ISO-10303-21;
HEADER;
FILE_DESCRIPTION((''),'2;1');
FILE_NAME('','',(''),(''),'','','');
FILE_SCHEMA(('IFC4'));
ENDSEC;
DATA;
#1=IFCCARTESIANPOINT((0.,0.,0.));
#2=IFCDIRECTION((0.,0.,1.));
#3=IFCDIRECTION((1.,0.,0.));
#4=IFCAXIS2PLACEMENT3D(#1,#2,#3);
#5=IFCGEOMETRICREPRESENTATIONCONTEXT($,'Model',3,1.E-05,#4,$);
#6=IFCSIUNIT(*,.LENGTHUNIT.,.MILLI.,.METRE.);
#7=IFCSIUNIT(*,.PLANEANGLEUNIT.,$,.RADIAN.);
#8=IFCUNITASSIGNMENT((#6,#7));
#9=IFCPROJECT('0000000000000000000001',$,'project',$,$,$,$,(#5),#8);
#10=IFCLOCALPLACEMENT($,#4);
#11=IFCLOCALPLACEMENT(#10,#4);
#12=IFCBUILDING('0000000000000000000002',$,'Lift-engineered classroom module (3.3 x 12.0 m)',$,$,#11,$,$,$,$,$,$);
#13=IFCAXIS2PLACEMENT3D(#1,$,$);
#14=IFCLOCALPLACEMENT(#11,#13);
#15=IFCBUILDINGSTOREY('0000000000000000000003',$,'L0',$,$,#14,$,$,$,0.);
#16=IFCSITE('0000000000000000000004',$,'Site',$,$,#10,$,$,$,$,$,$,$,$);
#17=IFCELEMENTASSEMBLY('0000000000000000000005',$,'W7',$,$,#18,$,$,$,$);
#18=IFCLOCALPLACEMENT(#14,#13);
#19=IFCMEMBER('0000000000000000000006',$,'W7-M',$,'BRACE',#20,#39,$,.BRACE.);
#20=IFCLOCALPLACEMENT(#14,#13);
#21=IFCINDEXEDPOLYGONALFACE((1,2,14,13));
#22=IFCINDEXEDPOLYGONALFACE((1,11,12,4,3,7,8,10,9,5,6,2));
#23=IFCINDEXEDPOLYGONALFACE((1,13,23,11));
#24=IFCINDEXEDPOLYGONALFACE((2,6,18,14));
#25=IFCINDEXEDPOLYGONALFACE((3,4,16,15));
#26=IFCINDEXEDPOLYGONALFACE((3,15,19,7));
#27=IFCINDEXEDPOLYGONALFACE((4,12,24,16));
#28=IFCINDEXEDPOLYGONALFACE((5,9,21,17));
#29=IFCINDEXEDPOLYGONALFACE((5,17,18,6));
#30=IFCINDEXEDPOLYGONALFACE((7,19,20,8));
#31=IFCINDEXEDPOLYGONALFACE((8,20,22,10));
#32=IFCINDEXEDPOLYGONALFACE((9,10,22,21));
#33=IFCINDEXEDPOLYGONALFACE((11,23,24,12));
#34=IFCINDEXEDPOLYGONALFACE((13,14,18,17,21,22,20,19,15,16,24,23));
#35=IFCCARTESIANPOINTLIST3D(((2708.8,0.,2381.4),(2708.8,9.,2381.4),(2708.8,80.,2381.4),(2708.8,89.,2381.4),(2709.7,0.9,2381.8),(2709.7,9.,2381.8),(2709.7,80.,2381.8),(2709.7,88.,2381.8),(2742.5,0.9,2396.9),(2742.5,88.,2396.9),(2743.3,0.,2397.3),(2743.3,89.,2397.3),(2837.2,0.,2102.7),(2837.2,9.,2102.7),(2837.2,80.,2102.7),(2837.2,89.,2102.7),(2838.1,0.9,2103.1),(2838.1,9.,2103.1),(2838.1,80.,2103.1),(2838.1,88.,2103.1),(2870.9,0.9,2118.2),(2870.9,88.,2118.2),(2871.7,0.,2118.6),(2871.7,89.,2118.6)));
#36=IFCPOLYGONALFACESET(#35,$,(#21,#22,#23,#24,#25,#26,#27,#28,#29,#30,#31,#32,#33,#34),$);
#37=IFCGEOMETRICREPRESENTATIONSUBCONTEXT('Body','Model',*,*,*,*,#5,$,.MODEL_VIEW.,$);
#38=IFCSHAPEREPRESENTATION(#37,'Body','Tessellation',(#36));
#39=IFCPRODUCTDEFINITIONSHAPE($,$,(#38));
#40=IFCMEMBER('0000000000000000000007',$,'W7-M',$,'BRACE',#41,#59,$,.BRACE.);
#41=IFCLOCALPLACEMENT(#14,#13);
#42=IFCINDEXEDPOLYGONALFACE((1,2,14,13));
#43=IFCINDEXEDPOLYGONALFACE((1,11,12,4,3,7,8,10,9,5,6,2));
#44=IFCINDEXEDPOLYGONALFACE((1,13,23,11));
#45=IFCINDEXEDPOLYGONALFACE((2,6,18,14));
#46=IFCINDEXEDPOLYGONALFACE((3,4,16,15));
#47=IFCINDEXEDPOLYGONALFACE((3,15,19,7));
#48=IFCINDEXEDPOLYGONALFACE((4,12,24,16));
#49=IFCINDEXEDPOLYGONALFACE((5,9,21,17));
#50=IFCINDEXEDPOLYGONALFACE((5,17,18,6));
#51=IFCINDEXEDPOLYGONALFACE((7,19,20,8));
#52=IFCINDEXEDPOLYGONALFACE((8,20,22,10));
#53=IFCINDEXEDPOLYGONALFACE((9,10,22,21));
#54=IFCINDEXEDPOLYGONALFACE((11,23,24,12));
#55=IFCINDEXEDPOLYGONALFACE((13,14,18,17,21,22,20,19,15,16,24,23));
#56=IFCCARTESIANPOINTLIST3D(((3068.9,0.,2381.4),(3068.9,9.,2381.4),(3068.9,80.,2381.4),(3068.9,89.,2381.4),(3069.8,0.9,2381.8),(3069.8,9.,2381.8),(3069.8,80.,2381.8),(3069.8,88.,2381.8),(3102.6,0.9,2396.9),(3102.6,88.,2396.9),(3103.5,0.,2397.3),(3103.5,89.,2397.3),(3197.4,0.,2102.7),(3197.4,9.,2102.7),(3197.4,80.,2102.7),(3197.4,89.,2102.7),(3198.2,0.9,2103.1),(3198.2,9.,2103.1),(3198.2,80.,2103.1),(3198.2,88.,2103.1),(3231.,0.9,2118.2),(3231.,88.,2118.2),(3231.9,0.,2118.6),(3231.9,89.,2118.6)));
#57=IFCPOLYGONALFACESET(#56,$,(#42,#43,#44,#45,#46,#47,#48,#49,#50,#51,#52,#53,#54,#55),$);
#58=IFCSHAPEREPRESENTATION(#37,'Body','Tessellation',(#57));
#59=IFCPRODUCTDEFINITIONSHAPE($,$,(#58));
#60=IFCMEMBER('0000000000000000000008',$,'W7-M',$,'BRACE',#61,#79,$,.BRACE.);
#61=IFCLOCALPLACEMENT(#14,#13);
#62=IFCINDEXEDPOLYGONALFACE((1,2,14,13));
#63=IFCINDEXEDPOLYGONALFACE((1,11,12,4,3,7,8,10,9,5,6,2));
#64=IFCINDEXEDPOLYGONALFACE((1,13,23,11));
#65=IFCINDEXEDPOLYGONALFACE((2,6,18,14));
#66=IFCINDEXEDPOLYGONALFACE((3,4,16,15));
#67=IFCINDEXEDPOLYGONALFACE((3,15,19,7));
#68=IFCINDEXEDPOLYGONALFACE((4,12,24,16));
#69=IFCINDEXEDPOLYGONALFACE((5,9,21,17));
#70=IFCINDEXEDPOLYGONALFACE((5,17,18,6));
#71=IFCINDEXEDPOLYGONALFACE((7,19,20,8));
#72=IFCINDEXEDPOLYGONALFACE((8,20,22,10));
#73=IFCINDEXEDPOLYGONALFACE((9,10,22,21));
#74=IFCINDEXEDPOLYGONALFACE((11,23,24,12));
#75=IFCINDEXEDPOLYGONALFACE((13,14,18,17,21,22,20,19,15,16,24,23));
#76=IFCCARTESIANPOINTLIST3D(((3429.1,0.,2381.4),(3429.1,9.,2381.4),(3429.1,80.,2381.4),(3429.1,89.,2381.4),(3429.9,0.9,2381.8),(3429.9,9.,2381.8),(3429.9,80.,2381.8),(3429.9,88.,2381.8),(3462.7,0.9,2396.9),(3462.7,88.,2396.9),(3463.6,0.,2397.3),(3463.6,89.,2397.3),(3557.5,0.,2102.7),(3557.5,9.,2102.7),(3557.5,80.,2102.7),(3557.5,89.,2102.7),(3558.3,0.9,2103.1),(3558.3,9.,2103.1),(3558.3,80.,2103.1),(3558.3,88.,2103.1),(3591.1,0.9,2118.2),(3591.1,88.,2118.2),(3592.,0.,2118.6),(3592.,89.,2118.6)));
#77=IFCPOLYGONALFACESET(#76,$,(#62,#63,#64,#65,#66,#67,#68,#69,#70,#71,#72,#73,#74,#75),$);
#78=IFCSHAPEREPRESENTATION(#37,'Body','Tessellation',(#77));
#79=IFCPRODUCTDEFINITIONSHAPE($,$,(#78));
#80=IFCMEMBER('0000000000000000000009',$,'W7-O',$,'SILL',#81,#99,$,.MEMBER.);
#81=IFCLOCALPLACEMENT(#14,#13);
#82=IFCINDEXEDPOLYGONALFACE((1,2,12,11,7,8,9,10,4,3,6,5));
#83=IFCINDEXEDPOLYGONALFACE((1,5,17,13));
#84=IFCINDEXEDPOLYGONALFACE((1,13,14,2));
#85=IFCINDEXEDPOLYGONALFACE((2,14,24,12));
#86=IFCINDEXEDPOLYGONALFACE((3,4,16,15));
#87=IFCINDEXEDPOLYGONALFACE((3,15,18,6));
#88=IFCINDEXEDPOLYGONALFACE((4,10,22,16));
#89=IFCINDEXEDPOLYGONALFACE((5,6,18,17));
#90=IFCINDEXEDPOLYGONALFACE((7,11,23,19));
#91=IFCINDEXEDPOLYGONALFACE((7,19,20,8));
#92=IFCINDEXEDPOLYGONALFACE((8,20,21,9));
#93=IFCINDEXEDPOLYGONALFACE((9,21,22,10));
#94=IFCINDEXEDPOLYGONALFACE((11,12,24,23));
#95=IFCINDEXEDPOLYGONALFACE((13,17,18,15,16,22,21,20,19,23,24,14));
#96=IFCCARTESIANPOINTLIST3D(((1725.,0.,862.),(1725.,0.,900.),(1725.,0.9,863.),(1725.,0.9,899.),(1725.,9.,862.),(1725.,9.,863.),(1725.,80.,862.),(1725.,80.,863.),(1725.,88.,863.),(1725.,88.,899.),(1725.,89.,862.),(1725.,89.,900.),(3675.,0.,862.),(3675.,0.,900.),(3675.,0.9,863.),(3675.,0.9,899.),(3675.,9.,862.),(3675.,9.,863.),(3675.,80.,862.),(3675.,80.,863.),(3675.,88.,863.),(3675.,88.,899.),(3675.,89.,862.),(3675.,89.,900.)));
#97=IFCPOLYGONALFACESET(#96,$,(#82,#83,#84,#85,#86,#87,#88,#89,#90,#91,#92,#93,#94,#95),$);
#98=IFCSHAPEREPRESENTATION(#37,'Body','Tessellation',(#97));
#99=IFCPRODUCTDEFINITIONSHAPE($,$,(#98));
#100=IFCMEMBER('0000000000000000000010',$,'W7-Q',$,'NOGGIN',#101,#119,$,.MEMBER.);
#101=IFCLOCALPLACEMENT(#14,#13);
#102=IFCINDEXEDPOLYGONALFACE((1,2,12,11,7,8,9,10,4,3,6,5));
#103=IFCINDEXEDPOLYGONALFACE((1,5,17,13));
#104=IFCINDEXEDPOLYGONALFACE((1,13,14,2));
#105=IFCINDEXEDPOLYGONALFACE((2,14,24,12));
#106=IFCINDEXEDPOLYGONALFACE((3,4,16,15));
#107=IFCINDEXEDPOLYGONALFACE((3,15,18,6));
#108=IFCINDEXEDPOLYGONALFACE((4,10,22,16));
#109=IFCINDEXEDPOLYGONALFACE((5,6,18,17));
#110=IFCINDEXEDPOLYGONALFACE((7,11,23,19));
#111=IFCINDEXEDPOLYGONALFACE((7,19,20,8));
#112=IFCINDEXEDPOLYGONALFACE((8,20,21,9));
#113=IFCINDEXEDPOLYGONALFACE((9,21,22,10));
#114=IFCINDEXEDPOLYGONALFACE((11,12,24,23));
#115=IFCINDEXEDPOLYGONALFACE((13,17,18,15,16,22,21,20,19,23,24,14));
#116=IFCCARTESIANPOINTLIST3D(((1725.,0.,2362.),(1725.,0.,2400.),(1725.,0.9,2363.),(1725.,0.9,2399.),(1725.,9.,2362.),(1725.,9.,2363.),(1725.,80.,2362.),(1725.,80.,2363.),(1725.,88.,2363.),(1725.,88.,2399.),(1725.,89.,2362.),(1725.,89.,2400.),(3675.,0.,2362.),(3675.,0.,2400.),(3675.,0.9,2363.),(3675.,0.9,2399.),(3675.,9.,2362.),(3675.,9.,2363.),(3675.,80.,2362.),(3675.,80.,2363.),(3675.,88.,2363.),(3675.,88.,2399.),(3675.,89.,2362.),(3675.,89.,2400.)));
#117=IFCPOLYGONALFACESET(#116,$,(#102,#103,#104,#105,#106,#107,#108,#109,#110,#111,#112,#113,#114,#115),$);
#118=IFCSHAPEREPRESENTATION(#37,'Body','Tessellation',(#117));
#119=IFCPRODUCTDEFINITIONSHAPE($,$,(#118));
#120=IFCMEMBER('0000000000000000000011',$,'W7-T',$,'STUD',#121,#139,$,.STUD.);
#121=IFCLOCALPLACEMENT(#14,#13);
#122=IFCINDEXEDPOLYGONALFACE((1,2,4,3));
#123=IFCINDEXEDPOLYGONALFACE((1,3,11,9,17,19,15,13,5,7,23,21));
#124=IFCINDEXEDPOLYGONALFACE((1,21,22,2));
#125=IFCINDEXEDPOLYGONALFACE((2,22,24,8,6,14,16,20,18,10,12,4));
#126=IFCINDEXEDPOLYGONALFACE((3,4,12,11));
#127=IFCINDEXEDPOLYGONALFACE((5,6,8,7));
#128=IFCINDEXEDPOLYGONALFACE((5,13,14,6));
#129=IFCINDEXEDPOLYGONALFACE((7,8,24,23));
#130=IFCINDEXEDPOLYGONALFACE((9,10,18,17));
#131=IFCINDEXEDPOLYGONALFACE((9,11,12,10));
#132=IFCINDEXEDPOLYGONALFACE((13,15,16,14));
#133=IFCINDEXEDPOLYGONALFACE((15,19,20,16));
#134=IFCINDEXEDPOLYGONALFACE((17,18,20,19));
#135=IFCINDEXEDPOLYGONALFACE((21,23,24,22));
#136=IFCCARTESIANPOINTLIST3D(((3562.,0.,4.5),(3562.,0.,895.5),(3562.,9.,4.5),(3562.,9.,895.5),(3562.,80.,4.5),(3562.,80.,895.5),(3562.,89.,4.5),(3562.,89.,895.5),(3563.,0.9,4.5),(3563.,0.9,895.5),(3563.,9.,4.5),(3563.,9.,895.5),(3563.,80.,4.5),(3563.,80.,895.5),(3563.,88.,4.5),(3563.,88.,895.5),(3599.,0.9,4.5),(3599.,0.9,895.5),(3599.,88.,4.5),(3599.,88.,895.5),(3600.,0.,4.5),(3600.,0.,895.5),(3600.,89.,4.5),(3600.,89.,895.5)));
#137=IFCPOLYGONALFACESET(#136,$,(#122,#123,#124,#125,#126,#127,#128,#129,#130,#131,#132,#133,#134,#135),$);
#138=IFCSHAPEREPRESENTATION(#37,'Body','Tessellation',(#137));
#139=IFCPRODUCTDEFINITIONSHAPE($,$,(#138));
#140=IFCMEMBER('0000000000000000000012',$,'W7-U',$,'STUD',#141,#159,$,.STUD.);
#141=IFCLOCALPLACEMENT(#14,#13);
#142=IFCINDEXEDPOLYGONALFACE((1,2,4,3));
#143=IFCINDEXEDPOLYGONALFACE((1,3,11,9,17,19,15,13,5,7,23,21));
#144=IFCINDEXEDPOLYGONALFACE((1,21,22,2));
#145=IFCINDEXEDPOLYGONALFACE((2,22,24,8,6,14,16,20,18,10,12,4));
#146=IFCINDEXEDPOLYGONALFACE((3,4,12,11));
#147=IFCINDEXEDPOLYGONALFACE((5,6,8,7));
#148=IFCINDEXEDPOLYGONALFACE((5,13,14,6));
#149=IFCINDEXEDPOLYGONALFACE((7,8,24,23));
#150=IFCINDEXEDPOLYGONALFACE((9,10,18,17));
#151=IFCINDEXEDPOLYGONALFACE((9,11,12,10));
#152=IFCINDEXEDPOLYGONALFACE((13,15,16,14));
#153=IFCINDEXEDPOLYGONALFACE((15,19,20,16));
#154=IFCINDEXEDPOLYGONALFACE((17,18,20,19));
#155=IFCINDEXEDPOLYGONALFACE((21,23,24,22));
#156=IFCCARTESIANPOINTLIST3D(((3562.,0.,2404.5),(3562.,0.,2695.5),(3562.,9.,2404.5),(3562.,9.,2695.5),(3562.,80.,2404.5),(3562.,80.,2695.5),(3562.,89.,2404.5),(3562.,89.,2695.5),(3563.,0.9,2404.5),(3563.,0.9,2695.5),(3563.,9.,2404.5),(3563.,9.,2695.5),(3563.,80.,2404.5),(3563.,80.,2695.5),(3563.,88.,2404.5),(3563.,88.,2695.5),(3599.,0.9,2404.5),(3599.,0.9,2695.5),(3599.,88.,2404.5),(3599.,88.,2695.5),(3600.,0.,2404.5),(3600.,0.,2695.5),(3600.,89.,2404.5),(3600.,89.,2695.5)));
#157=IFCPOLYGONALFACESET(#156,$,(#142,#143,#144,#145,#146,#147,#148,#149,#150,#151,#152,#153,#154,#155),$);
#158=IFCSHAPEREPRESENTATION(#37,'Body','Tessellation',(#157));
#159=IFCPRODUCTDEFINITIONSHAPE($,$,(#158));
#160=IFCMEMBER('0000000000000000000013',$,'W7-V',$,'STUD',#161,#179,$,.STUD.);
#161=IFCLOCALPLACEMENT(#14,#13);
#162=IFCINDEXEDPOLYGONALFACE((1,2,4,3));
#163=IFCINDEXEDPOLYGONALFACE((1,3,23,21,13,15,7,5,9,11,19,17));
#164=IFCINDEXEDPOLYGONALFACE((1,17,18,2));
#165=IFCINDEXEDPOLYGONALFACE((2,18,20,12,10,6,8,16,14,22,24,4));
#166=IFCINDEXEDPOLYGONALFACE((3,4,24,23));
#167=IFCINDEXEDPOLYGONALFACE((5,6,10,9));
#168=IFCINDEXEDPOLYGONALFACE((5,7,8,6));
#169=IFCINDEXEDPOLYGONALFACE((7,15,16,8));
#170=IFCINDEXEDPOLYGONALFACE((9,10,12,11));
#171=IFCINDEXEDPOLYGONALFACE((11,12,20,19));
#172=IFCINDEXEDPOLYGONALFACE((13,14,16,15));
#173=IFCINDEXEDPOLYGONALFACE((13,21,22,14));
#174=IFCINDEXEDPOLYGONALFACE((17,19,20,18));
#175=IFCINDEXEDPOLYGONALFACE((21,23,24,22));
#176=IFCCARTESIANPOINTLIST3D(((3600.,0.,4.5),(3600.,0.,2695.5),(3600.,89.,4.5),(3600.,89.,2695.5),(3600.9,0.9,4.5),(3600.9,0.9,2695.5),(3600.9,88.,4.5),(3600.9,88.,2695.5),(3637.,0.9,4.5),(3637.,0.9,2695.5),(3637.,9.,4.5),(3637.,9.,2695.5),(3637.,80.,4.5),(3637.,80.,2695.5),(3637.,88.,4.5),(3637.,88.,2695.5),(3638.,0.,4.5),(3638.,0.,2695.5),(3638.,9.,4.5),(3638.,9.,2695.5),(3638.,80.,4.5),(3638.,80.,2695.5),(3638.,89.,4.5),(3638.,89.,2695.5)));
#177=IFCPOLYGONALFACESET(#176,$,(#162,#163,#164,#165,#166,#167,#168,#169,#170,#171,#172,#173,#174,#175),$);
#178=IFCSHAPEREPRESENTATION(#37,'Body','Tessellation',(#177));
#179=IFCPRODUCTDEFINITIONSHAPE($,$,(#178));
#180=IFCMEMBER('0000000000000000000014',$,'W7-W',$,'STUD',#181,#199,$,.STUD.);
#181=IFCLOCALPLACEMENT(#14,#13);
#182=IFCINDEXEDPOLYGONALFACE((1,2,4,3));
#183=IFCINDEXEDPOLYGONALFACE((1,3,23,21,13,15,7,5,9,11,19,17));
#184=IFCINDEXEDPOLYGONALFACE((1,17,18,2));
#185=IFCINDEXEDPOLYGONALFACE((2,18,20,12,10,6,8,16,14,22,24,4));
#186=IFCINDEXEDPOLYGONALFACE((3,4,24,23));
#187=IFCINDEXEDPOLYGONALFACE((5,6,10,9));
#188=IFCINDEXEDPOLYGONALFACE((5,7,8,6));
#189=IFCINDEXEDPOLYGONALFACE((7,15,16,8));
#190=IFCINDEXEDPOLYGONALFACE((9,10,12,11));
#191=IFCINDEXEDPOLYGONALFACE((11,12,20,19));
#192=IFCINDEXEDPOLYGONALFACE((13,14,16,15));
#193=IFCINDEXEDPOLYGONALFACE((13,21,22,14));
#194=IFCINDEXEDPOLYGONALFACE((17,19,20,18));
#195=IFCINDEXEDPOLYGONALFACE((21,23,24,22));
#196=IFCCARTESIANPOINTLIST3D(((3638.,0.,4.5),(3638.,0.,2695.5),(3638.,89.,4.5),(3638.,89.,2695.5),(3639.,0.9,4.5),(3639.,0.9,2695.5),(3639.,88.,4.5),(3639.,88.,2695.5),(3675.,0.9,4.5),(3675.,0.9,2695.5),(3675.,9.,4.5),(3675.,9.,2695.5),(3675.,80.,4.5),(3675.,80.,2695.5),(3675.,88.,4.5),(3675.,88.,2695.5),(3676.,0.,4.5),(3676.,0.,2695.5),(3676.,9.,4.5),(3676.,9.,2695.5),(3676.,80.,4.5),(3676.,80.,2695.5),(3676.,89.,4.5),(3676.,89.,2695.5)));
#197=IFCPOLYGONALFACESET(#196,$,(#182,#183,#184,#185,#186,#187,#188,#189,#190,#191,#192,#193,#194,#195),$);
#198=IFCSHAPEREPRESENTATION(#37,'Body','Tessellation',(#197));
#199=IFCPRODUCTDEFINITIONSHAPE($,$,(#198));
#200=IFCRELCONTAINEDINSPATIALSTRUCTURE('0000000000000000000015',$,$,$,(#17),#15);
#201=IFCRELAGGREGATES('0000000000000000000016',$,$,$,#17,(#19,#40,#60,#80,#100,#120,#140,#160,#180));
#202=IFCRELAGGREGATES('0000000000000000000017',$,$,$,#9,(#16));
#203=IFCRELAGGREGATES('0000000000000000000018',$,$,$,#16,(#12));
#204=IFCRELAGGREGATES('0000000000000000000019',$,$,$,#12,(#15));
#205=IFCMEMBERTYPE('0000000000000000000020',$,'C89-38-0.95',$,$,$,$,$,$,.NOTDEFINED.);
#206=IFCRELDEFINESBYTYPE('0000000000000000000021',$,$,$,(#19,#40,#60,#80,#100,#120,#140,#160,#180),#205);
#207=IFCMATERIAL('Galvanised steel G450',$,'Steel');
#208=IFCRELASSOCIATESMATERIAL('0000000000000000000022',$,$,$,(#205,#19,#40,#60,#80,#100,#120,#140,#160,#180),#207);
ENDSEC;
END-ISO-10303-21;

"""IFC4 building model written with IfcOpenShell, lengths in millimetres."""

from ifc_helpers import new_model, si_unit, frame, origin, origin_with_axes, origin_2d, place, context, subcontext, project, spatial, c_section, extrude, material, material_profile, profile_set, profile_usage, type_object, element, aggregate, save


model = new_model("IFC4")

# Units and contexts
model_context = context("Model", 3, precision=1e-05, world=origin_with_axes())
body_context = subcontext(model_context, "Body", "Model", "MODEL_VIEW")
ifc_project = project(units=[si_unit("LENGTHUNIT", "METRE", prefix="MILLI"), si_unit("PLANEANGLEUNIT", "RADIAN")], contexts=[model_context])

# Site, building, storey
site_placement = place(None, origin_with_axes())
site = spatial("IfcSite", under=ifc_project, at=site_placement, Name="Site")
building_placement = place(site_placement, origin_with_axes())
building = spatial("IfcBuilding", under=site, at=building_placement, Name="Lift-engineered classroom module (3.3 x 12.0 m)")
storey_placement = place(building_placement, origin())
storey = spatial("IfcBuildingStorey", under=building, at=storey_placement, Name="L0", Elevation=0.0)

# Element assembly, members
assembly_1_placement = place(storey_placement, frame((900.0, 44.5, 0.0)))
assembly_1 = element("IfcElementAssembly", 1, at=assembly_1_placement, inside=storey, Name="W7")
ifc_material = material(Name="Galvanised steel G450", Category="Steel")
ifc_material_profile = material_profile(ifc_material, c_section(Depth=89.0, Width=38.0, WallThickness=0.9, Girth=9.0, at=origin_2d()), Name="C89-38-0.95")
ifc_profile_set = profile_set([ifc_material_profile], Name="C89-38-0.95")
ifc_profile_usage = profile_usage(ifc_profile_set)
member_type = type_object("IfcMemberType", Name="C89-38-0.95", PredefinedType="NOTDEFINED", material=ifc_profile_set)
member_1_placement = place(assembly_1_placement, frame((1954.5, 0.0, 2110.6), z_axis=(-0.418465, 0.0, 0.908233), x_axis=(-0.908233, 0.0, -0.418465)))
member_1 = element("IfcMember", 2, at=member_1_placement, type_object=member_type, material=ifc_profile_usage, Name="W7-M", ObjectType="BRACE", PredefinedType="BRACE", context=body_context, shape_type="SweptSolid", body=[
    extrude(c_section(Depth=89.0, Width=38.0, WallThickness=0.9, Girth=9.0, at=origin_2d()), origin(), (0.0, 0.0, 1.0), 306.9),
])
member_2_placement = place(assembly_1_placement, frame((2314.6, 0.0, 2110.6), z_axis=(-0.418465, 0.0, 0.908233), x_axis=(-0.908233, 0.0, -0.418465)))
member_2 = element("IfcMember", 3, at=member_2_placement, type_object=member_type, material=ifc_profile_usage, Name="W7-M", ObjectType="BRACE", PredefinedType="BRACE", context=body_context, shape_type="SweptSolid", body=[
    extrude(c_section(Depth=89.0, Width=38.0, WallThickness=0.9, Girth=9.0, at=origin_2d()), origin(), (0.0, 0.0, 1.0), 306.9),
])
member_3_placement = place(assembly_1_placement, frame((2674.7, 0.0, 2110.6), z_axis=(-0.418465, 0.0, 0.908233), x_axis=(-0.908233, 0.0, -0.418465)))
member_3 = element("IfcMember", 4, at=member_3_placement, type_object=member_type, material=ifc_profile_usage, Name="W7-M", ObjectType="BRACE", PredefinedType="BRACE", context=body_context, shape_type="SweptSolid", body=[
    extrude(c_section(Depth=89.0, Width=38.0, WallThickness=0.9, Girth=9.0, at=origin_2d()), origin(), (0.0, 0.0, 1.0), 306.9),
])
member_4_placement = place(assembly_1_placement, frame((2775.1, 0.0, 881.0), z_axis=(-1.0, 0.0, 0.0), x_axis=(0.0, 0.0, -1.0)))
member_4 = element("IfcMember", 5, at=member_4_placement, type_object=member_type, material=ifc_profile_usage, Name="W7-O", ObjectType="SILL", PredefinedType="MEMBER", context=body_context, shape_type="SweptSolid", body=[
    extrude(c_section(Depth=89.0, Width=38.0, WallThickness=0.9, Girth=9.0, at=origin_2d()), origin(), (0.0, 0.0, 1.0), 1950.1),
])
member_5_placement = place(assembly_1_placement, frame((2775.1, 0.0, 2381.0), z_axis=(-1.0, 0.0, 0.0), x_axis=(0.0, 0.0, -1.0)))
member_5 = element("IfcMember", 6, at=member_5_placement, type_object=member_type, material=ifc_profile_usage, Name="W7-Q", ObjectType="NOGGIN", PredefinedType="MEMBER", context=body_context, shape_type="SweptSolid", body=[
    extrude(c_section(Depth=89.0, Width=38.0, WallThickness=0.9, Girth=9.0, at=origin_2d()), origin(), (0.0, 0.0, 1.0), 1950.1),
])
member_6_placement = place(assembly_1_placement, frame((2681.0, 0.0, 4.5), z_axis=(0.0, 0.0, 1.0), x_axis=(-1.0, 0.0, 0.0)))
member_6 = element("IfcMember", 7, at=member_6_placement, type_object=member_type, material=ifc_profile_usage, Name="W7-T", ObjectType="STUD", PredefinedType="STUD", context=body_context, shape_type="SweptSolid", body=[
    extrude(c_section(Depth=89.0, Width=38.0, WallThickness=0.9, Girth=9.0, at=origin_2d()), origin(), (0.0, 0.0, 1.0), 891.0),
])
member_7_placement = place(assembly_1_placement, frame((2681.0, 0.0, 2404.5), z_axis=(0.0, 0.0, 1.0), x_axis=(-1.0, 0.0, 0.0)))
member_7 = element("IfcMember", 8, at=member_7_placement, type_object=member_type, material=ifc_profile_usage, Name="W7-U", ObjectType="STUD", PredefinedType="STUD", context=body_context, shape_type="SweptSolid", body=[
    extrude(c_section(Depth=89.0, Width=38.0, WallThickness=0.9, Girth=9.0, at=origin_2d()), origin(), (0.0, 0.0, 1.0), 291.0),
])
member_8_placement = place(assembly_1_placement, frame((2719.0, 0.0, 2695.5), z_axis=(0.0, 0.0, -1.0), x_axis=(1.0, 0.0, 0.0)))
member_8 = element("IfcMember", 9, at=member_8_placement, type_object=member_type, material=ifc_profile_usage, Name="W7-V", ObjectType="STUD", PredefinedType="STUD", context=body_context, shape_type="SweptSolid", body=[
    extrude(c_section(Depth=89.0, Width=38.0, WallThickness=0.9, Girth=9.0, at=origin_2d()), origin(), (0.0, 0.0, 1.0), 2691.0),
])
member_9_placement = place(assembly_1_placement, frame((2757.0, 0.0, 2695.5), z_axis=(0.0, 0.0, -1.0), x_axis=(1.0, 0.0, 0.0)))
member_9 = element("IfcMember", 10, at=member_9_placement, type_object=member_type, material=ifc_profile_usage, Name="W7-W", ObjectType="STUD", PredefinedType="STUD", context=body_context, shape_type="SweptSolid", body=[
    extrude(c_section(Depth=89.0, Width=38.0, WallThickness=0.9, Girth=9.0, at=origin_2d()), origin(), (0.0, 0.0, 1.0), 2691.0),
])
aggregate(assembly_1, [member_1, member_2, member_3, member_4, member_5, member_6, member_7, member_8, member_9])

save(model, "model.ifc")
